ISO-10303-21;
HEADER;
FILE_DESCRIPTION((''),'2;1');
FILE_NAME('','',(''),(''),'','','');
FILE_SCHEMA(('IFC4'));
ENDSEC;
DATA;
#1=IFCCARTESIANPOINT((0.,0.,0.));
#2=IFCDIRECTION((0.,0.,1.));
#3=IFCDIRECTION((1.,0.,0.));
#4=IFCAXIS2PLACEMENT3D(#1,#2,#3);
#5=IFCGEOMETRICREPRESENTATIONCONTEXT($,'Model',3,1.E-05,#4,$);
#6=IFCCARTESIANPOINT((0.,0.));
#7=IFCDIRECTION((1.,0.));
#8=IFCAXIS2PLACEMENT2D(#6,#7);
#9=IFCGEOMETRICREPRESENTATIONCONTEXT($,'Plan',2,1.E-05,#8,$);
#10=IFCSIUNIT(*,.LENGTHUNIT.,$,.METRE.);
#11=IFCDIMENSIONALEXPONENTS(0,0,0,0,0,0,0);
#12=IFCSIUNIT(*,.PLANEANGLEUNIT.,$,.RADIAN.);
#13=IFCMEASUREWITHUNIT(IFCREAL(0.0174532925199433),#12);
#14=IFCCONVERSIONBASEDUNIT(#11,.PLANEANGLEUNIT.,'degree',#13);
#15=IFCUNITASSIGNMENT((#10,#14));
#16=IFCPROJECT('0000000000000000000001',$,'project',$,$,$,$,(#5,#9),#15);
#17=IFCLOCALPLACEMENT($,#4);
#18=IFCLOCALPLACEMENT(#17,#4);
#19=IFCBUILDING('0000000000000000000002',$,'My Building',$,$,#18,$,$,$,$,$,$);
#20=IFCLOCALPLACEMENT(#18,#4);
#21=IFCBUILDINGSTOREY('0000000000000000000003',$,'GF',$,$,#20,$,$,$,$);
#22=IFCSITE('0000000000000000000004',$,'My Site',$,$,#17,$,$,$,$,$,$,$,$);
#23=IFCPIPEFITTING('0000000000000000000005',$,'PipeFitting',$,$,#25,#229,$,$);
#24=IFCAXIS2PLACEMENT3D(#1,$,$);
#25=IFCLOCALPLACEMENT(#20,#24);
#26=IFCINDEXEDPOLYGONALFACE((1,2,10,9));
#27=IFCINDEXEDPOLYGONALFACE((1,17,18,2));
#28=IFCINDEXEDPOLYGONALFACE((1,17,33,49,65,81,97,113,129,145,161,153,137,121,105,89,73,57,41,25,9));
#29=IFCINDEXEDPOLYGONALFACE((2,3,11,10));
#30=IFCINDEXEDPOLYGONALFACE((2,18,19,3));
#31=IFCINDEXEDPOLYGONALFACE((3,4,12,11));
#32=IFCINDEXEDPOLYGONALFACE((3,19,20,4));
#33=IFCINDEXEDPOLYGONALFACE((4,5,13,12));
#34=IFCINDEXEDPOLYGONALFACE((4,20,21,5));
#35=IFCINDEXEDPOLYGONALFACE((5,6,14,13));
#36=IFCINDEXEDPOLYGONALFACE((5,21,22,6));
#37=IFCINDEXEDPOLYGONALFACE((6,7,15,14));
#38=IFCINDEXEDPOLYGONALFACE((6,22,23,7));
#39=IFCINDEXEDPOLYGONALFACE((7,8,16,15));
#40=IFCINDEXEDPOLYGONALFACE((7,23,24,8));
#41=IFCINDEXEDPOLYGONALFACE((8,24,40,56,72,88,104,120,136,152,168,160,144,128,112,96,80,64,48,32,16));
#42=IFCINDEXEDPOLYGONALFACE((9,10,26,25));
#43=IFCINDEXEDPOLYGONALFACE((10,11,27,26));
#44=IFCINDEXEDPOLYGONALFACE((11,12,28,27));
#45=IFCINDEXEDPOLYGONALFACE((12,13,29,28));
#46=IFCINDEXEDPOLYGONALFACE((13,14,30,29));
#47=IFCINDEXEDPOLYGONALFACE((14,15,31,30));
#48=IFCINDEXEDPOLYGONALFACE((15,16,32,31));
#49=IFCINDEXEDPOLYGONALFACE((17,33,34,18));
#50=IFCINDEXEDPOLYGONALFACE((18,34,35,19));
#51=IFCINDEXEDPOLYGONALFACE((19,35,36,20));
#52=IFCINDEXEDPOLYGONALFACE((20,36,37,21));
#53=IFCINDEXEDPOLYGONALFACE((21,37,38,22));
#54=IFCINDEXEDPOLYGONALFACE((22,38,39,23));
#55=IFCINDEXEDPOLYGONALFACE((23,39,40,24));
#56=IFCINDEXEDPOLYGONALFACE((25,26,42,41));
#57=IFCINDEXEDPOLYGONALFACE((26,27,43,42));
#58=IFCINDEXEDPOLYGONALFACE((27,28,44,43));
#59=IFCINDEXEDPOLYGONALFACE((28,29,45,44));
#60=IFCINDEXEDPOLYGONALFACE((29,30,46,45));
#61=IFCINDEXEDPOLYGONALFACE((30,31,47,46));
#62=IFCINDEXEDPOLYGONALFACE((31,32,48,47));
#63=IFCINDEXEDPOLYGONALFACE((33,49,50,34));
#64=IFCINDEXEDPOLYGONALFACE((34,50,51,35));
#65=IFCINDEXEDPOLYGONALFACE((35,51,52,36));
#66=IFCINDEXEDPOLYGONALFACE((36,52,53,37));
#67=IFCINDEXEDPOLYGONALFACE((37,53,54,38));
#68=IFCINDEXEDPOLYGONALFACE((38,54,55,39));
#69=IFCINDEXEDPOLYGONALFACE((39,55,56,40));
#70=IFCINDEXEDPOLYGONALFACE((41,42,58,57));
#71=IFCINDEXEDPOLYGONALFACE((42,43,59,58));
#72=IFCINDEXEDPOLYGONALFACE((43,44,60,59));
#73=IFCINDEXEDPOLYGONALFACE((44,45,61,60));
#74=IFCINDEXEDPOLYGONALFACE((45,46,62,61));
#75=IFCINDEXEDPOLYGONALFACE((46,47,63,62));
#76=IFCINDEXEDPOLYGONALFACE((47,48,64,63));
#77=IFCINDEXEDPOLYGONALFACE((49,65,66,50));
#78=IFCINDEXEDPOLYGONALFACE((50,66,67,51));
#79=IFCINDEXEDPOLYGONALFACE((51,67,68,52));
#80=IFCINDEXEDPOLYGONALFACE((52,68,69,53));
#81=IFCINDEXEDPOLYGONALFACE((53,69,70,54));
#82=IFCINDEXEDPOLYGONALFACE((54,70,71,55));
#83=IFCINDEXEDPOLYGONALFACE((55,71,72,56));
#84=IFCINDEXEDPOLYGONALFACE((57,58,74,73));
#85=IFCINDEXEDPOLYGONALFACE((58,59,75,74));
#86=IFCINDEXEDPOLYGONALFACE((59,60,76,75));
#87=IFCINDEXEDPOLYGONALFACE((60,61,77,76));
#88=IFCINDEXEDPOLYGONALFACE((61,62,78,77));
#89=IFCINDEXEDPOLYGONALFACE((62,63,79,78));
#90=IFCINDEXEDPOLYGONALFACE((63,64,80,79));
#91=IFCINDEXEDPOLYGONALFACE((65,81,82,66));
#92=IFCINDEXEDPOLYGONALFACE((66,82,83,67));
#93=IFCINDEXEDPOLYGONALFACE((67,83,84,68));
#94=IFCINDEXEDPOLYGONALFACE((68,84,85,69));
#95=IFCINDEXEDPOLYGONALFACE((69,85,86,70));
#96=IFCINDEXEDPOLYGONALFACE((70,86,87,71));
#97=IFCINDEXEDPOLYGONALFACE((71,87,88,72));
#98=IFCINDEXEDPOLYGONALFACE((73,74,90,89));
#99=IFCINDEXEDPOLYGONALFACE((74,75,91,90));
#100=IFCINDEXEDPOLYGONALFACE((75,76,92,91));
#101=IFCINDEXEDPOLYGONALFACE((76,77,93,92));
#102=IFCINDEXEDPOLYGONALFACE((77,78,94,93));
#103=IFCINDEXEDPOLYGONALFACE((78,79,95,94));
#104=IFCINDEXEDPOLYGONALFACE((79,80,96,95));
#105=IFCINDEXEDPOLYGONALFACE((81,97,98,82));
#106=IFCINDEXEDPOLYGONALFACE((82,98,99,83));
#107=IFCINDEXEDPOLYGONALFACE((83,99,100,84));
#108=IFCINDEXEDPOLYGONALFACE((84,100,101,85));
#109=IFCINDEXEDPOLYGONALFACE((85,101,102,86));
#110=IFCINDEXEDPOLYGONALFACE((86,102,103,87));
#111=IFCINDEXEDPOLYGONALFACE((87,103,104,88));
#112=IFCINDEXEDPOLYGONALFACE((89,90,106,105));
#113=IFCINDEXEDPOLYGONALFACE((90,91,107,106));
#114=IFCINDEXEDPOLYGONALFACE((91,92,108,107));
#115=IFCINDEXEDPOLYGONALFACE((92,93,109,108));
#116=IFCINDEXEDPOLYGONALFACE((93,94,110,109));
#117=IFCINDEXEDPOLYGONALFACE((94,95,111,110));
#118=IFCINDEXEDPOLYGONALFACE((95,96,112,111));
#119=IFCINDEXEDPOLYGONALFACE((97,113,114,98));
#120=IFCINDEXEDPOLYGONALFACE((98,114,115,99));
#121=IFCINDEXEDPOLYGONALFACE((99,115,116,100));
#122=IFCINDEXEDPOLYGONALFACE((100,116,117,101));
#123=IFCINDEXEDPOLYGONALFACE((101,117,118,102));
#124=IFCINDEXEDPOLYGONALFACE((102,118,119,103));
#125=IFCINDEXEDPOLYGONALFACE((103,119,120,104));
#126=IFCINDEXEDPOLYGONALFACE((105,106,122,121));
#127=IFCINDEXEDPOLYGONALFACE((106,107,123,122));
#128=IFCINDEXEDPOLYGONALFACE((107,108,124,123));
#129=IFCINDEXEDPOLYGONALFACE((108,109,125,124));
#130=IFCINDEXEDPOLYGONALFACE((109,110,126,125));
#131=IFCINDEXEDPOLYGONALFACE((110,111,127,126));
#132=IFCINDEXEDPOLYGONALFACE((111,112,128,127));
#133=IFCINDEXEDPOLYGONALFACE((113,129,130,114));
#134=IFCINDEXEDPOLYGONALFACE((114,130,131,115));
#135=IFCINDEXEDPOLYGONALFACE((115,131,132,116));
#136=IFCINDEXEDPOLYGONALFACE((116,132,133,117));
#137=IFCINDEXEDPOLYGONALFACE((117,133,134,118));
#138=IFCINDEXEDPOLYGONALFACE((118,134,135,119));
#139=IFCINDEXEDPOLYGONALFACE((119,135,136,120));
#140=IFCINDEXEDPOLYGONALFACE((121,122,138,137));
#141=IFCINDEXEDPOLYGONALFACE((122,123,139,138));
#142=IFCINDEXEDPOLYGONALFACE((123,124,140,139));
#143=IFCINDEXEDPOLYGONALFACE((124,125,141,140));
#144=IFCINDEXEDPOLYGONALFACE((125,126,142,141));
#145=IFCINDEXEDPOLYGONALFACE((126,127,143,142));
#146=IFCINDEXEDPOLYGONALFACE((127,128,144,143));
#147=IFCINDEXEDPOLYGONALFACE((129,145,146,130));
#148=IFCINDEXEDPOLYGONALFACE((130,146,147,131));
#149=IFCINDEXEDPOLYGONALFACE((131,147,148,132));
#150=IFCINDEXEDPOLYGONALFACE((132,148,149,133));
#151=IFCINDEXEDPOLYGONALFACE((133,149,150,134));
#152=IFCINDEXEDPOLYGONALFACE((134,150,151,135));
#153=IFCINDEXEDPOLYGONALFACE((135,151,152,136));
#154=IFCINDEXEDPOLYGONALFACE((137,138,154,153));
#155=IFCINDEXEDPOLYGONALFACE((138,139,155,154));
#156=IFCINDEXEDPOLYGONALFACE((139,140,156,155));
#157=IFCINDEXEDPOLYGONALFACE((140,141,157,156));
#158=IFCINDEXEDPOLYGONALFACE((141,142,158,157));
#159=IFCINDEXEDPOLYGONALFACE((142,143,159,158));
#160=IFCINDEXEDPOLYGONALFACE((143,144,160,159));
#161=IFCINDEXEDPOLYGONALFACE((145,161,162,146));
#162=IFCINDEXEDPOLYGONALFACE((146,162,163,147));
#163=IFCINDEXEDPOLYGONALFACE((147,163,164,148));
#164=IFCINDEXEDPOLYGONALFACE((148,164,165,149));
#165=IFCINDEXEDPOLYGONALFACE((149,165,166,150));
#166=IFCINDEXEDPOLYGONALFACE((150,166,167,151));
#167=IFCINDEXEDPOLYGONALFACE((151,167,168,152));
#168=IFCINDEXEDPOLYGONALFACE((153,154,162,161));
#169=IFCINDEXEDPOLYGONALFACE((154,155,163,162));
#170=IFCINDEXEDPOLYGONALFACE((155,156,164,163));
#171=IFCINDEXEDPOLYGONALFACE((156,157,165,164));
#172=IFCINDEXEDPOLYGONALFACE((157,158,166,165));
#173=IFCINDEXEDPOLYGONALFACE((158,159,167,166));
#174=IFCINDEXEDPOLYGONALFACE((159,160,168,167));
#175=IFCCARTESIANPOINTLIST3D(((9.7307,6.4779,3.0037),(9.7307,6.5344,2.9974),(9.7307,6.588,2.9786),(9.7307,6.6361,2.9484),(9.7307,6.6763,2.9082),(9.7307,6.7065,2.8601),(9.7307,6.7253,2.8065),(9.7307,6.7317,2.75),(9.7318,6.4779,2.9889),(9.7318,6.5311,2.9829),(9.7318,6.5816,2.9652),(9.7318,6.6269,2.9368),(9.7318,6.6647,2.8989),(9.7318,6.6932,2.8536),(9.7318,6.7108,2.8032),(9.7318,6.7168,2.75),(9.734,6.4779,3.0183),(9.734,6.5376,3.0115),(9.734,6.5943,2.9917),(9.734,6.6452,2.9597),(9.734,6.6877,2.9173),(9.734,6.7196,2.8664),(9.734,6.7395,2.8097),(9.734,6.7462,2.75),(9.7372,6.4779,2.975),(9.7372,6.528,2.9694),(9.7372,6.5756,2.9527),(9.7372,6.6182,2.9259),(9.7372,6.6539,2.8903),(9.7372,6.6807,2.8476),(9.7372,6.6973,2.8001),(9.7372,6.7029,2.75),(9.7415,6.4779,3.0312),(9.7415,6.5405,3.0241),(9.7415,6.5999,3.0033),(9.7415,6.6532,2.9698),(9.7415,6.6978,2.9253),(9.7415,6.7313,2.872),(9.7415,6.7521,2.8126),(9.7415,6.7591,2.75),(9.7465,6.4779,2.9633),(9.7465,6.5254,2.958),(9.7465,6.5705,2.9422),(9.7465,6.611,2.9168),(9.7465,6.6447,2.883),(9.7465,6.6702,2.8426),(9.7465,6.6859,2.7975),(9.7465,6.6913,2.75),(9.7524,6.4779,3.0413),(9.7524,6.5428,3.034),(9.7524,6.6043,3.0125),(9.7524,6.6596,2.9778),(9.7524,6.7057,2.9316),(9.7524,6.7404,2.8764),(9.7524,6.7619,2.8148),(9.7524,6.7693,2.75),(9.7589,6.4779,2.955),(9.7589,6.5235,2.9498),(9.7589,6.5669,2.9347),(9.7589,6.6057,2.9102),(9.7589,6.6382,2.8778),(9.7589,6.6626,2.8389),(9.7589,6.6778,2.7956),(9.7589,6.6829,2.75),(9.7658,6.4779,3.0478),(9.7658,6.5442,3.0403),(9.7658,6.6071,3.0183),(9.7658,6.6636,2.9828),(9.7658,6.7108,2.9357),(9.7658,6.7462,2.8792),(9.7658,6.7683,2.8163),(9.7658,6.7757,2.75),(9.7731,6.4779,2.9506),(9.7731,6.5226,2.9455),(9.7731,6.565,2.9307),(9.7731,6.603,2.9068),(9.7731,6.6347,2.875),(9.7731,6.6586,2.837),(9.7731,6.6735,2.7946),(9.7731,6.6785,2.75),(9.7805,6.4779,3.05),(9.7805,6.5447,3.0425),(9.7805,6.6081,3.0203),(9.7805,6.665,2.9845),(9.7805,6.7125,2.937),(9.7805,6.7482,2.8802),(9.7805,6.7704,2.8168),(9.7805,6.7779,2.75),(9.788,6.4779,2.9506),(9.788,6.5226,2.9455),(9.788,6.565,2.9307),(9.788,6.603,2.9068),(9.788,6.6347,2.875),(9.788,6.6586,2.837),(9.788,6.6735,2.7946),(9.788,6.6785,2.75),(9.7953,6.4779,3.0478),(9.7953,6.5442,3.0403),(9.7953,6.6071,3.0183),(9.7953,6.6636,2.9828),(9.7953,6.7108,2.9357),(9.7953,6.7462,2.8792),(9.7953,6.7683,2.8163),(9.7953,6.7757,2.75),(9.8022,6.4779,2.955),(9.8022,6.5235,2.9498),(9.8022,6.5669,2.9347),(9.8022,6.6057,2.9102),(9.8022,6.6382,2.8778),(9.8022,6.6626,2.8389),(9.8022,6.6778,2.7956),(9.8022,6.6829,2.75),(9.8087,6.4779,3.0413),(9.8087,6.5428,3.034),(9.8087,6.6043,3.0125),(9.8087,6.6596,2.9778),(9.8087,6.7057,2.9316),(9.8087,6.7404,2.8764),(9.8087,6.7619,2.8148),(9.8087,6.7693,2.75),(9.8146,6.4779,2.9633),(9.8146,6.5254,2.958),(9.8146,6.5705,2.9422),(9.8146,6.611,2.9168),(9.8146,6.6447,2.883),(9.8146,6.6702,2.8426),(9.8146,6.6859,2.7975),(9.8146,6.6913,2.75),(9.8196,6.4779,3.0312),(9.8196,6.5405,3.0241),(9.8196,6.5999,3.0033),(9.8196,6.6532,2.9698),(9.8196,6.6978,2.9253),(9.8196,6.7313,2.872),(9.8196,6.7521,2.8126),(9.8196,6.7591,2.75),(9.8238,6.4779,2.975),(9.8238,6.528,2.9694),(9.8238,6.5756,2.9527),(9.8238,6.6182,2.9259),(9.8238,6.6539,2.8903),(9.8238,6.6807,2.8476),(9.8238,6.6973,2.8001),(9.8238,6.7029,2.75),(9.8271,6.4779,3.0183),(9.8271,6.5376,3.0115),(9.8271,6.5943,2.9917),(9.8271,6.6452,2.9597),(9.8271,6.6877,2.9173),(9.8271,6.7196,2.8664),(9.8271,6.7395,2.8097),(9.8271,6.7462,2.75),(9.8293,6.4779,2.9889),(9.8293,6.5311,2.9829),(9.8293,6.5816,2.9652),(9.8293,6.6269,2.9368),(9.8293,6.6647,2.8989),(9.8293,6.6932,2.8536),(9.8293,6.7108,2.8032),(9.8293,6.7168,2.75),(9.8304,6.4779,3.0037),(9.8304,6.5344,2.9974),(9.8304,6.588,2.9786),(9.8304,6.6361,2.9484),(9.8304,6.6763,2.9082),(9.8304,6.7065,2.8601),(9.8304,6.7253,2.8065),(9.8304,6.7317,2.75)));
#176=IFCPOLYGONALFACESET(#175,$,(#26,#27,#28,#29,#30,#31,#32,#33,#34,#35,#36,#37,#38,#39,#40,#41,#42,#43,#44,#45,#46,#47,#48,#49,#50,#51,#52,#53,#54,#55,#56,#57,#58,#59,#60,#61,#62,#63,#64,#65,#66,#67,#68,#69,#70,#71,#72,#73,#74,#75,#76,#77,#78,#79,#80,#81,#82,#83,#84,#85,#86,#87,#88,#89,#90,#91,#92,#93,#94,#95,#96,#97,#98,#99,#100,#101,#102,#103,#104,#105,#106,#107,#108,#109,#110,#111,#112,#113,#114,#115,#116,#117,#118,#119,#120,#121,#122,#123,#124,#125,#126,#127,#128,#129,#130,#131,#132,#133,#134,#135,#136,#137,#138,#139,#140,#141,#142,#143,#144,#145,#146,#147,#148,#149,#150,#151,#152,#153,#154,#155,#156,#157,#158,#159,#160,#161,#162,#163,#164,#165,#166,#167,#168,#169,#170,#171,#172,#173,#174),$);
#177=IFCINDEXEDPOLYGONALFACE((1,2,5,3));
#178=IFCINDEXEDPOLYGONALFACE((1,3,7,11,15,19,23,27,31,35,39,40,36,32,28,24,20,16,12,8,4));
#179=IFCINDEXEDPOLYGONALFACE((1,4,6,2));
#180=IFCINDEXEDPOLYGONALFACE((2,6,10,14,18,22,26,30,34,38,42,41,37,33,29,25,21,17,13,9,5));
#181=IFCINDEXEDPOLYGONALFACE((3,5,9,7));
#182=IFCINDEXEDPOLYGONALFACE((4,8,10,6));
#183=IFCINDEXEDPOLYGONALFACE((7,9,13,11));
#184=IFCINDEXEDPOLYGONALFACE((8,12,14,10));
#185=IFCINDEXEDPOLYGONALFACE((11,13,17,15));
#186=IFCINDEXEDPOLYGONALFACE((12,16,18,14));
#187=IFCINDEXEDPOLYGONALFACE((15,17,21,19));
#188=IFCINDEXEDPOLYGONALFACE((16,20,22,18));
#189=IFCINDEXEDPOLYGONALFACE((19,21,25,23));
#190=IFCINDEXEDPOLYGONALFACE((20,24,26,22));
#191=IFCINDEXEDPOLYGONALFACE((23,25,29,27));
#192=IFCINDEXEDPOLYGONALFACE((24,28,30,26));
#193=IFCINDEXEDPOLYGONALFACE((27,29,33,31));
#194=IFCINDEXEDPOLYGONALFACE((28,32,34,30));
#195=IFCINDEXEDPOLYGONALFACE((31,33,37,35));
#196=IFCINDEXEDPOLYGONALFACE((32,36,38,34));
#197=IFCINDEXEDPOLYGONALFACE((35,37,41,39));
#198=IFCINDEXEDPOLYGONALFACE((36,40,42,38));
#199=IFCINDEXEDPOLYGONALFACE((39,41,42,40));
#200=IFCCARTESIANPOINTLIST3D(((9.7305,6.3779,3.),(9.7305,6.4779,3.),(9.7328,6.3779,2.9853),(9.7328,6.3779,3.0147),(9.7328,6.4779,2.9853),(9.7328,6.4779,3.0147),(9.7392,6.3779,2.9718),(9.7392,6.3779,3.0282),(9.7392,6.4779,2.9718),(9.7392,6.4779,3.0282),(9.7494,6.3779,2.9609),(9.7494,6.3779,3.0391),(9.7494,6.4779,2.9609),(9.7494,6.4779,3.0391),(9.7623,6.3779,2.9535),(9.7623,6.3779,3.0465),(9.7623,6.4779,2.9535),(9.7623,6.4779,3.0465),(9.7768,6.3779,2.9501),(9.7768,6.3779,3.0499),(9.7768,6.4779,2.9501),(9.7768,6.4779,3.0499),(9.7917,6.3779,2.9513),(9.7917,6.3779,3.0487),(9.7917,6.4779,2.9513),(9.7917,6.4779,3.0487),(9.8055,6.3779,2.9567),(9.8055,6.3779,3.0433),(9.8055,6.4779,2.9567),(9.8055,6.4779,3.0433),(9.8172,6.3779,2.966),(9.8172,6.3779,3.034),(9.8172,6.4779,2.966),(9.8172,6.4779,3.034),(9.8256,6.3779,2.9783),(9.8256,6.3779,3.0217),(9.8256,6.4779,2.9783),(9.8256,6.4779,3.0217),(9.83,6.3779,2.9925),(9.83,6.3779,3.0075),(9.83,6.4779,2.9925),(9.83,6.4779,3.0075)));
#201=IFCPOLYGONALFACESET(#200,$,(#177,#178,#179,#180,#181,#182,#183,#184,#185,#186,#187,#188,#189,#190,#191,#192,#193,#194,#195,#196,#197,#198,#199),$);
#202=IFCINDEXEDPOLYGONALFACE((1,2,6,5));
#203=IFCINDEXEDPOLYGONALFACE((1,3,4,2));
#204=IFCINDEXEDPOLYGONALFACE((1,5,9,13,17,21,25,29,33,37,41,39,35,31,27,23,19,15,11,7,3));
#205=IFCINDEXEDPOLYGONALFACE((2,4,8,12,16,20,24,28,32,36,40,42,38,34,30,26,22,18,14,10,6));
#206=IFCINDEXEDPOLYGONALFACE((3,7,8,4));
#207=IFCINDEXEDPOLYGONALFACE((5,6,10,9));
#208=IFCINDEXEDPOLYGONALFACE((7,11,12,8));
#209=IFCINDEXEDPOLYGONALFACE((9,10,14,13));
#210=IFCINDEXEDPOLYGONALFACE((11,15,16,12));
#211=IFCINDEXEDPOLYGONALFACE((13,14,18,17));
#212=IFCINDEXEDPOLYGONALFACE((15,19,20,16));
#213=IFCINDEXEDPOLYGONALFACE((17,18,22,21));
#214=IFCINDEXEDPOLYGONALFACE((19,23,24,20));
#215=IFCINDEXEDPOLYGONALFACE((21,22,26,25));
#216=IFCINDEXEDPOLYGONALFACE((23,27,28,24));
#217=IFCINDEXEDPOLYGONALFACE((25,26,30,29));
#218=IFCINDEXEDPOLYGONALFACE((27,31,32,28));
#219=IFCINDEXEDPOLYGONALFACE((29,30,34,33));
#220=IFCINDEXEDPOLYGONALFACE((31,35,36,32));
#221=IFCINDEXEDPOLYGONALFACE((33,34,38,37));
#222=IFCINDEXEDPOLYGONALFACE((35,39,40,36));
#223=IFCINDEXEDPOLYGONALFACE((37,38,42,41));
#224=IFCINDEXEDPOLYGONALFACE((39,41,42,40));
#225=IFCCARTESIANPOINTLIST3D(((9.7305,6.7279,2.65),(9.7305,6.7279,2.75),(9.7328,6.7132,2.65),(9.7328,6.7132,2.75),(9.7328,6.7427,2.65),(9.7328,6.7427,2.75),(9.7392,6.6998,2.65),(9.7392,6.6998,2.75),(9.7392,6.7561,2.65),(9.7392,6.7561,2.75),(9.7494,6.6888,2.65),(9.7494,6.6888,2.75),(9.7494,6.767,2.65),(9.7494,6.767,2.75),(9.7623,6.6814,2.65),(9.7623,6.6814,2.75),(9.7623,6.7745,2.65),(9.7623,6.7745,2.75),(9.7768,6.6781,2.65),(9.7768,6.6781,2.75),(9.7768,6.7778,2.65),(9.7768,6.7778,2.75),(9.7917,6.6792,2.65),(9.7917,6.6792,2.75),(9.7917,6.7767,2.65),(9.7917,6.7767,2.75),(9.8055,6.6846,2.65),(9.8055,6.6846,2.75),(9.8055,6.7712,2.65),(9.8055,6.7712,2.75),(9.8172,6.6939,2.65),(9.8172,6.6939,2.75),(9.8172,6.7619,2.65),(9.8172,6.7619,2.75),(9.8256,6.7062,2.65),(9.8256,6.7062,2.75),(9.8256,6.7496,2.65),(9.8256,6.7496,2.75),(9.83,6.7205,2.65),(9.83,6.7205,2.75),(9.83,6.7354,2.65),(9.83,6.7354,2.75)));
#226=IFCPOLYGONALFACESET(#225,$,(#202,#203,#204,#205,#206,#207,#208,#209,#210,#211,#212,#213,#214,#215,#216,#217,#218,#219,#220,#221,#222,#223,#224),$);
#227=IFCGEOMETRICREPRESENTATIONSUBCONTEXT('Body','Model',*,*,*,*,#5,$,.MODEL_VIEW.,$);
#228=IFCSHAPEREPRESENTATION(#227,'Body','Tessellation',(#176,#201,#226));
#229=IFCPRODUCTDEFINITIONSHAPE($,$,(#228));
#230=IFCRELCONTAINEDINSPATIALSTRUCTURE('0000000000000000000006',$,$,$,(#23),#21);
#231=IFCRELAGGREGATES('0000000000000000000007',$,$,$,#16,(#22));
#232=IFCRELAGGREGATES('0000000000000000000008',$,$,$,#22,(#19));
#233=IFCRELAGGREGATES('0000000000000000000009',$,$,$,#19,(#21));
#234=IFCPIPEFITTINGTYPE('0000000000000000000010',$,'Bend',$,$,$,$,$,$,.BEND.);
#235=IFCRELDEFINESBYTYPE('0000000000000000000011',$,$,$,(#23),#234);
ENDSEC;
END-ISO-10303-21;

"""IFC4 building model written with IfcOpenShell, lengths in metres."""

from ifc_helpers import new_model, entity, si_unit, converted_unit, frame, origin_with_axes, origin_2d_with_axis, place, context, subcontext, project, spatial, circle, extrude, source, transform, mapped, type_object, type_shapes, element, save


model = new_model("IFC4")

# Units and contexts
model_context = context("Model", 3, precision=1e-05, world=origin_with_axes())
plan_context = context("Plan", 2, precision=1e-05, world=origin_2d_with_axis())
body_context_1 = subcontext(model_context, "Body", "Model", "MODEL_VIEW")
ifc_project = project(units=[si_unit("LENGTHUNIT", "METRE"), converted_unit("PLANEANGLEUNIT", "degree", entity("IfcReal", 0.0174532925199433), si_unit("PLANEANGLEUNIT", "RADIAN"), dimensions=[0, 0, 0, 0, 0, 0, 0])], contexts=[model_context, plan_context])

# Site, building, storey
site_placement = place(None, origin_with_axes())
site = spatial("IfcSite", under=ifc_project, at=site_placement, Name="My Site")
building_placement = place(site_placement, origin_with_axes())
building = spatial("IfcBuilding", under=site, at=building_placement, Name="My Building")
storey_placement = place(building_placement, origin_with_axes())
storey = spatial("IfcBuildingStorey", under=building, at=storey_placement, Name="GF")

# Pipe fitting
pipe_fitting_type = type_object("IfcPipeFittingType", Name="Bend", PredefinedType="BEND")
shared_shape_1 = source(origin_with_axes(), body_context_1, "Body", "SolidModel", [
    entity("IfcSweptDiskSolid", entity("IfcIndexedPolyCurve", entity("IfcCartesianPointList3D", [[0.0, 0.0, 0.1], [0.0, -0.0732, 0.2768], [0.0, -0.25, 0.35]]), [entity("IfcArcIndex", [1, 2, 3])]), 0.05),
    extrude(circle(Radius=0.05), origin_with_axes(), (0.0, 0.0, 1.0), 0.1),
    extrude(circle(Radius=0.05), frame((0.0, -0.25, 0.35), z_axis=(0.0, -1.0, 0.0), x_axis=(1.0, 0.0, 0.0)), (0.0, 0.0, 1.0), 0.1),
])
type_shapes(pipe_fitting_type, [shared_shape_1])
for number, where, z_axis, x_axis, name in (
    (1, (9.7805, 6.3779, 3.0), (0.0, 1.0, 0.0), (-1.0, 0.0, 0.0), "PipeFitting"),
):
    element("IfcPipeFitting", number, at=place(storey_placement, frame(where, z_axis=z_axis, x_axis=x_axis)), inside=storey, type_object=pipe_fitting_type, Name=name, context=body_context_1, shape_type="MappedRepresentation", body=[
        mapped(shared_shape_1, transform((0.0, 0.0, 0.0), x_axis=(1.0, 0.0, 0.0), y_axis=(0.0, 1.0, 0.0), z_axis=(0.0, 0.0, 1.0), scale=1.0)),
    ])

save(model, "model.ifc")
